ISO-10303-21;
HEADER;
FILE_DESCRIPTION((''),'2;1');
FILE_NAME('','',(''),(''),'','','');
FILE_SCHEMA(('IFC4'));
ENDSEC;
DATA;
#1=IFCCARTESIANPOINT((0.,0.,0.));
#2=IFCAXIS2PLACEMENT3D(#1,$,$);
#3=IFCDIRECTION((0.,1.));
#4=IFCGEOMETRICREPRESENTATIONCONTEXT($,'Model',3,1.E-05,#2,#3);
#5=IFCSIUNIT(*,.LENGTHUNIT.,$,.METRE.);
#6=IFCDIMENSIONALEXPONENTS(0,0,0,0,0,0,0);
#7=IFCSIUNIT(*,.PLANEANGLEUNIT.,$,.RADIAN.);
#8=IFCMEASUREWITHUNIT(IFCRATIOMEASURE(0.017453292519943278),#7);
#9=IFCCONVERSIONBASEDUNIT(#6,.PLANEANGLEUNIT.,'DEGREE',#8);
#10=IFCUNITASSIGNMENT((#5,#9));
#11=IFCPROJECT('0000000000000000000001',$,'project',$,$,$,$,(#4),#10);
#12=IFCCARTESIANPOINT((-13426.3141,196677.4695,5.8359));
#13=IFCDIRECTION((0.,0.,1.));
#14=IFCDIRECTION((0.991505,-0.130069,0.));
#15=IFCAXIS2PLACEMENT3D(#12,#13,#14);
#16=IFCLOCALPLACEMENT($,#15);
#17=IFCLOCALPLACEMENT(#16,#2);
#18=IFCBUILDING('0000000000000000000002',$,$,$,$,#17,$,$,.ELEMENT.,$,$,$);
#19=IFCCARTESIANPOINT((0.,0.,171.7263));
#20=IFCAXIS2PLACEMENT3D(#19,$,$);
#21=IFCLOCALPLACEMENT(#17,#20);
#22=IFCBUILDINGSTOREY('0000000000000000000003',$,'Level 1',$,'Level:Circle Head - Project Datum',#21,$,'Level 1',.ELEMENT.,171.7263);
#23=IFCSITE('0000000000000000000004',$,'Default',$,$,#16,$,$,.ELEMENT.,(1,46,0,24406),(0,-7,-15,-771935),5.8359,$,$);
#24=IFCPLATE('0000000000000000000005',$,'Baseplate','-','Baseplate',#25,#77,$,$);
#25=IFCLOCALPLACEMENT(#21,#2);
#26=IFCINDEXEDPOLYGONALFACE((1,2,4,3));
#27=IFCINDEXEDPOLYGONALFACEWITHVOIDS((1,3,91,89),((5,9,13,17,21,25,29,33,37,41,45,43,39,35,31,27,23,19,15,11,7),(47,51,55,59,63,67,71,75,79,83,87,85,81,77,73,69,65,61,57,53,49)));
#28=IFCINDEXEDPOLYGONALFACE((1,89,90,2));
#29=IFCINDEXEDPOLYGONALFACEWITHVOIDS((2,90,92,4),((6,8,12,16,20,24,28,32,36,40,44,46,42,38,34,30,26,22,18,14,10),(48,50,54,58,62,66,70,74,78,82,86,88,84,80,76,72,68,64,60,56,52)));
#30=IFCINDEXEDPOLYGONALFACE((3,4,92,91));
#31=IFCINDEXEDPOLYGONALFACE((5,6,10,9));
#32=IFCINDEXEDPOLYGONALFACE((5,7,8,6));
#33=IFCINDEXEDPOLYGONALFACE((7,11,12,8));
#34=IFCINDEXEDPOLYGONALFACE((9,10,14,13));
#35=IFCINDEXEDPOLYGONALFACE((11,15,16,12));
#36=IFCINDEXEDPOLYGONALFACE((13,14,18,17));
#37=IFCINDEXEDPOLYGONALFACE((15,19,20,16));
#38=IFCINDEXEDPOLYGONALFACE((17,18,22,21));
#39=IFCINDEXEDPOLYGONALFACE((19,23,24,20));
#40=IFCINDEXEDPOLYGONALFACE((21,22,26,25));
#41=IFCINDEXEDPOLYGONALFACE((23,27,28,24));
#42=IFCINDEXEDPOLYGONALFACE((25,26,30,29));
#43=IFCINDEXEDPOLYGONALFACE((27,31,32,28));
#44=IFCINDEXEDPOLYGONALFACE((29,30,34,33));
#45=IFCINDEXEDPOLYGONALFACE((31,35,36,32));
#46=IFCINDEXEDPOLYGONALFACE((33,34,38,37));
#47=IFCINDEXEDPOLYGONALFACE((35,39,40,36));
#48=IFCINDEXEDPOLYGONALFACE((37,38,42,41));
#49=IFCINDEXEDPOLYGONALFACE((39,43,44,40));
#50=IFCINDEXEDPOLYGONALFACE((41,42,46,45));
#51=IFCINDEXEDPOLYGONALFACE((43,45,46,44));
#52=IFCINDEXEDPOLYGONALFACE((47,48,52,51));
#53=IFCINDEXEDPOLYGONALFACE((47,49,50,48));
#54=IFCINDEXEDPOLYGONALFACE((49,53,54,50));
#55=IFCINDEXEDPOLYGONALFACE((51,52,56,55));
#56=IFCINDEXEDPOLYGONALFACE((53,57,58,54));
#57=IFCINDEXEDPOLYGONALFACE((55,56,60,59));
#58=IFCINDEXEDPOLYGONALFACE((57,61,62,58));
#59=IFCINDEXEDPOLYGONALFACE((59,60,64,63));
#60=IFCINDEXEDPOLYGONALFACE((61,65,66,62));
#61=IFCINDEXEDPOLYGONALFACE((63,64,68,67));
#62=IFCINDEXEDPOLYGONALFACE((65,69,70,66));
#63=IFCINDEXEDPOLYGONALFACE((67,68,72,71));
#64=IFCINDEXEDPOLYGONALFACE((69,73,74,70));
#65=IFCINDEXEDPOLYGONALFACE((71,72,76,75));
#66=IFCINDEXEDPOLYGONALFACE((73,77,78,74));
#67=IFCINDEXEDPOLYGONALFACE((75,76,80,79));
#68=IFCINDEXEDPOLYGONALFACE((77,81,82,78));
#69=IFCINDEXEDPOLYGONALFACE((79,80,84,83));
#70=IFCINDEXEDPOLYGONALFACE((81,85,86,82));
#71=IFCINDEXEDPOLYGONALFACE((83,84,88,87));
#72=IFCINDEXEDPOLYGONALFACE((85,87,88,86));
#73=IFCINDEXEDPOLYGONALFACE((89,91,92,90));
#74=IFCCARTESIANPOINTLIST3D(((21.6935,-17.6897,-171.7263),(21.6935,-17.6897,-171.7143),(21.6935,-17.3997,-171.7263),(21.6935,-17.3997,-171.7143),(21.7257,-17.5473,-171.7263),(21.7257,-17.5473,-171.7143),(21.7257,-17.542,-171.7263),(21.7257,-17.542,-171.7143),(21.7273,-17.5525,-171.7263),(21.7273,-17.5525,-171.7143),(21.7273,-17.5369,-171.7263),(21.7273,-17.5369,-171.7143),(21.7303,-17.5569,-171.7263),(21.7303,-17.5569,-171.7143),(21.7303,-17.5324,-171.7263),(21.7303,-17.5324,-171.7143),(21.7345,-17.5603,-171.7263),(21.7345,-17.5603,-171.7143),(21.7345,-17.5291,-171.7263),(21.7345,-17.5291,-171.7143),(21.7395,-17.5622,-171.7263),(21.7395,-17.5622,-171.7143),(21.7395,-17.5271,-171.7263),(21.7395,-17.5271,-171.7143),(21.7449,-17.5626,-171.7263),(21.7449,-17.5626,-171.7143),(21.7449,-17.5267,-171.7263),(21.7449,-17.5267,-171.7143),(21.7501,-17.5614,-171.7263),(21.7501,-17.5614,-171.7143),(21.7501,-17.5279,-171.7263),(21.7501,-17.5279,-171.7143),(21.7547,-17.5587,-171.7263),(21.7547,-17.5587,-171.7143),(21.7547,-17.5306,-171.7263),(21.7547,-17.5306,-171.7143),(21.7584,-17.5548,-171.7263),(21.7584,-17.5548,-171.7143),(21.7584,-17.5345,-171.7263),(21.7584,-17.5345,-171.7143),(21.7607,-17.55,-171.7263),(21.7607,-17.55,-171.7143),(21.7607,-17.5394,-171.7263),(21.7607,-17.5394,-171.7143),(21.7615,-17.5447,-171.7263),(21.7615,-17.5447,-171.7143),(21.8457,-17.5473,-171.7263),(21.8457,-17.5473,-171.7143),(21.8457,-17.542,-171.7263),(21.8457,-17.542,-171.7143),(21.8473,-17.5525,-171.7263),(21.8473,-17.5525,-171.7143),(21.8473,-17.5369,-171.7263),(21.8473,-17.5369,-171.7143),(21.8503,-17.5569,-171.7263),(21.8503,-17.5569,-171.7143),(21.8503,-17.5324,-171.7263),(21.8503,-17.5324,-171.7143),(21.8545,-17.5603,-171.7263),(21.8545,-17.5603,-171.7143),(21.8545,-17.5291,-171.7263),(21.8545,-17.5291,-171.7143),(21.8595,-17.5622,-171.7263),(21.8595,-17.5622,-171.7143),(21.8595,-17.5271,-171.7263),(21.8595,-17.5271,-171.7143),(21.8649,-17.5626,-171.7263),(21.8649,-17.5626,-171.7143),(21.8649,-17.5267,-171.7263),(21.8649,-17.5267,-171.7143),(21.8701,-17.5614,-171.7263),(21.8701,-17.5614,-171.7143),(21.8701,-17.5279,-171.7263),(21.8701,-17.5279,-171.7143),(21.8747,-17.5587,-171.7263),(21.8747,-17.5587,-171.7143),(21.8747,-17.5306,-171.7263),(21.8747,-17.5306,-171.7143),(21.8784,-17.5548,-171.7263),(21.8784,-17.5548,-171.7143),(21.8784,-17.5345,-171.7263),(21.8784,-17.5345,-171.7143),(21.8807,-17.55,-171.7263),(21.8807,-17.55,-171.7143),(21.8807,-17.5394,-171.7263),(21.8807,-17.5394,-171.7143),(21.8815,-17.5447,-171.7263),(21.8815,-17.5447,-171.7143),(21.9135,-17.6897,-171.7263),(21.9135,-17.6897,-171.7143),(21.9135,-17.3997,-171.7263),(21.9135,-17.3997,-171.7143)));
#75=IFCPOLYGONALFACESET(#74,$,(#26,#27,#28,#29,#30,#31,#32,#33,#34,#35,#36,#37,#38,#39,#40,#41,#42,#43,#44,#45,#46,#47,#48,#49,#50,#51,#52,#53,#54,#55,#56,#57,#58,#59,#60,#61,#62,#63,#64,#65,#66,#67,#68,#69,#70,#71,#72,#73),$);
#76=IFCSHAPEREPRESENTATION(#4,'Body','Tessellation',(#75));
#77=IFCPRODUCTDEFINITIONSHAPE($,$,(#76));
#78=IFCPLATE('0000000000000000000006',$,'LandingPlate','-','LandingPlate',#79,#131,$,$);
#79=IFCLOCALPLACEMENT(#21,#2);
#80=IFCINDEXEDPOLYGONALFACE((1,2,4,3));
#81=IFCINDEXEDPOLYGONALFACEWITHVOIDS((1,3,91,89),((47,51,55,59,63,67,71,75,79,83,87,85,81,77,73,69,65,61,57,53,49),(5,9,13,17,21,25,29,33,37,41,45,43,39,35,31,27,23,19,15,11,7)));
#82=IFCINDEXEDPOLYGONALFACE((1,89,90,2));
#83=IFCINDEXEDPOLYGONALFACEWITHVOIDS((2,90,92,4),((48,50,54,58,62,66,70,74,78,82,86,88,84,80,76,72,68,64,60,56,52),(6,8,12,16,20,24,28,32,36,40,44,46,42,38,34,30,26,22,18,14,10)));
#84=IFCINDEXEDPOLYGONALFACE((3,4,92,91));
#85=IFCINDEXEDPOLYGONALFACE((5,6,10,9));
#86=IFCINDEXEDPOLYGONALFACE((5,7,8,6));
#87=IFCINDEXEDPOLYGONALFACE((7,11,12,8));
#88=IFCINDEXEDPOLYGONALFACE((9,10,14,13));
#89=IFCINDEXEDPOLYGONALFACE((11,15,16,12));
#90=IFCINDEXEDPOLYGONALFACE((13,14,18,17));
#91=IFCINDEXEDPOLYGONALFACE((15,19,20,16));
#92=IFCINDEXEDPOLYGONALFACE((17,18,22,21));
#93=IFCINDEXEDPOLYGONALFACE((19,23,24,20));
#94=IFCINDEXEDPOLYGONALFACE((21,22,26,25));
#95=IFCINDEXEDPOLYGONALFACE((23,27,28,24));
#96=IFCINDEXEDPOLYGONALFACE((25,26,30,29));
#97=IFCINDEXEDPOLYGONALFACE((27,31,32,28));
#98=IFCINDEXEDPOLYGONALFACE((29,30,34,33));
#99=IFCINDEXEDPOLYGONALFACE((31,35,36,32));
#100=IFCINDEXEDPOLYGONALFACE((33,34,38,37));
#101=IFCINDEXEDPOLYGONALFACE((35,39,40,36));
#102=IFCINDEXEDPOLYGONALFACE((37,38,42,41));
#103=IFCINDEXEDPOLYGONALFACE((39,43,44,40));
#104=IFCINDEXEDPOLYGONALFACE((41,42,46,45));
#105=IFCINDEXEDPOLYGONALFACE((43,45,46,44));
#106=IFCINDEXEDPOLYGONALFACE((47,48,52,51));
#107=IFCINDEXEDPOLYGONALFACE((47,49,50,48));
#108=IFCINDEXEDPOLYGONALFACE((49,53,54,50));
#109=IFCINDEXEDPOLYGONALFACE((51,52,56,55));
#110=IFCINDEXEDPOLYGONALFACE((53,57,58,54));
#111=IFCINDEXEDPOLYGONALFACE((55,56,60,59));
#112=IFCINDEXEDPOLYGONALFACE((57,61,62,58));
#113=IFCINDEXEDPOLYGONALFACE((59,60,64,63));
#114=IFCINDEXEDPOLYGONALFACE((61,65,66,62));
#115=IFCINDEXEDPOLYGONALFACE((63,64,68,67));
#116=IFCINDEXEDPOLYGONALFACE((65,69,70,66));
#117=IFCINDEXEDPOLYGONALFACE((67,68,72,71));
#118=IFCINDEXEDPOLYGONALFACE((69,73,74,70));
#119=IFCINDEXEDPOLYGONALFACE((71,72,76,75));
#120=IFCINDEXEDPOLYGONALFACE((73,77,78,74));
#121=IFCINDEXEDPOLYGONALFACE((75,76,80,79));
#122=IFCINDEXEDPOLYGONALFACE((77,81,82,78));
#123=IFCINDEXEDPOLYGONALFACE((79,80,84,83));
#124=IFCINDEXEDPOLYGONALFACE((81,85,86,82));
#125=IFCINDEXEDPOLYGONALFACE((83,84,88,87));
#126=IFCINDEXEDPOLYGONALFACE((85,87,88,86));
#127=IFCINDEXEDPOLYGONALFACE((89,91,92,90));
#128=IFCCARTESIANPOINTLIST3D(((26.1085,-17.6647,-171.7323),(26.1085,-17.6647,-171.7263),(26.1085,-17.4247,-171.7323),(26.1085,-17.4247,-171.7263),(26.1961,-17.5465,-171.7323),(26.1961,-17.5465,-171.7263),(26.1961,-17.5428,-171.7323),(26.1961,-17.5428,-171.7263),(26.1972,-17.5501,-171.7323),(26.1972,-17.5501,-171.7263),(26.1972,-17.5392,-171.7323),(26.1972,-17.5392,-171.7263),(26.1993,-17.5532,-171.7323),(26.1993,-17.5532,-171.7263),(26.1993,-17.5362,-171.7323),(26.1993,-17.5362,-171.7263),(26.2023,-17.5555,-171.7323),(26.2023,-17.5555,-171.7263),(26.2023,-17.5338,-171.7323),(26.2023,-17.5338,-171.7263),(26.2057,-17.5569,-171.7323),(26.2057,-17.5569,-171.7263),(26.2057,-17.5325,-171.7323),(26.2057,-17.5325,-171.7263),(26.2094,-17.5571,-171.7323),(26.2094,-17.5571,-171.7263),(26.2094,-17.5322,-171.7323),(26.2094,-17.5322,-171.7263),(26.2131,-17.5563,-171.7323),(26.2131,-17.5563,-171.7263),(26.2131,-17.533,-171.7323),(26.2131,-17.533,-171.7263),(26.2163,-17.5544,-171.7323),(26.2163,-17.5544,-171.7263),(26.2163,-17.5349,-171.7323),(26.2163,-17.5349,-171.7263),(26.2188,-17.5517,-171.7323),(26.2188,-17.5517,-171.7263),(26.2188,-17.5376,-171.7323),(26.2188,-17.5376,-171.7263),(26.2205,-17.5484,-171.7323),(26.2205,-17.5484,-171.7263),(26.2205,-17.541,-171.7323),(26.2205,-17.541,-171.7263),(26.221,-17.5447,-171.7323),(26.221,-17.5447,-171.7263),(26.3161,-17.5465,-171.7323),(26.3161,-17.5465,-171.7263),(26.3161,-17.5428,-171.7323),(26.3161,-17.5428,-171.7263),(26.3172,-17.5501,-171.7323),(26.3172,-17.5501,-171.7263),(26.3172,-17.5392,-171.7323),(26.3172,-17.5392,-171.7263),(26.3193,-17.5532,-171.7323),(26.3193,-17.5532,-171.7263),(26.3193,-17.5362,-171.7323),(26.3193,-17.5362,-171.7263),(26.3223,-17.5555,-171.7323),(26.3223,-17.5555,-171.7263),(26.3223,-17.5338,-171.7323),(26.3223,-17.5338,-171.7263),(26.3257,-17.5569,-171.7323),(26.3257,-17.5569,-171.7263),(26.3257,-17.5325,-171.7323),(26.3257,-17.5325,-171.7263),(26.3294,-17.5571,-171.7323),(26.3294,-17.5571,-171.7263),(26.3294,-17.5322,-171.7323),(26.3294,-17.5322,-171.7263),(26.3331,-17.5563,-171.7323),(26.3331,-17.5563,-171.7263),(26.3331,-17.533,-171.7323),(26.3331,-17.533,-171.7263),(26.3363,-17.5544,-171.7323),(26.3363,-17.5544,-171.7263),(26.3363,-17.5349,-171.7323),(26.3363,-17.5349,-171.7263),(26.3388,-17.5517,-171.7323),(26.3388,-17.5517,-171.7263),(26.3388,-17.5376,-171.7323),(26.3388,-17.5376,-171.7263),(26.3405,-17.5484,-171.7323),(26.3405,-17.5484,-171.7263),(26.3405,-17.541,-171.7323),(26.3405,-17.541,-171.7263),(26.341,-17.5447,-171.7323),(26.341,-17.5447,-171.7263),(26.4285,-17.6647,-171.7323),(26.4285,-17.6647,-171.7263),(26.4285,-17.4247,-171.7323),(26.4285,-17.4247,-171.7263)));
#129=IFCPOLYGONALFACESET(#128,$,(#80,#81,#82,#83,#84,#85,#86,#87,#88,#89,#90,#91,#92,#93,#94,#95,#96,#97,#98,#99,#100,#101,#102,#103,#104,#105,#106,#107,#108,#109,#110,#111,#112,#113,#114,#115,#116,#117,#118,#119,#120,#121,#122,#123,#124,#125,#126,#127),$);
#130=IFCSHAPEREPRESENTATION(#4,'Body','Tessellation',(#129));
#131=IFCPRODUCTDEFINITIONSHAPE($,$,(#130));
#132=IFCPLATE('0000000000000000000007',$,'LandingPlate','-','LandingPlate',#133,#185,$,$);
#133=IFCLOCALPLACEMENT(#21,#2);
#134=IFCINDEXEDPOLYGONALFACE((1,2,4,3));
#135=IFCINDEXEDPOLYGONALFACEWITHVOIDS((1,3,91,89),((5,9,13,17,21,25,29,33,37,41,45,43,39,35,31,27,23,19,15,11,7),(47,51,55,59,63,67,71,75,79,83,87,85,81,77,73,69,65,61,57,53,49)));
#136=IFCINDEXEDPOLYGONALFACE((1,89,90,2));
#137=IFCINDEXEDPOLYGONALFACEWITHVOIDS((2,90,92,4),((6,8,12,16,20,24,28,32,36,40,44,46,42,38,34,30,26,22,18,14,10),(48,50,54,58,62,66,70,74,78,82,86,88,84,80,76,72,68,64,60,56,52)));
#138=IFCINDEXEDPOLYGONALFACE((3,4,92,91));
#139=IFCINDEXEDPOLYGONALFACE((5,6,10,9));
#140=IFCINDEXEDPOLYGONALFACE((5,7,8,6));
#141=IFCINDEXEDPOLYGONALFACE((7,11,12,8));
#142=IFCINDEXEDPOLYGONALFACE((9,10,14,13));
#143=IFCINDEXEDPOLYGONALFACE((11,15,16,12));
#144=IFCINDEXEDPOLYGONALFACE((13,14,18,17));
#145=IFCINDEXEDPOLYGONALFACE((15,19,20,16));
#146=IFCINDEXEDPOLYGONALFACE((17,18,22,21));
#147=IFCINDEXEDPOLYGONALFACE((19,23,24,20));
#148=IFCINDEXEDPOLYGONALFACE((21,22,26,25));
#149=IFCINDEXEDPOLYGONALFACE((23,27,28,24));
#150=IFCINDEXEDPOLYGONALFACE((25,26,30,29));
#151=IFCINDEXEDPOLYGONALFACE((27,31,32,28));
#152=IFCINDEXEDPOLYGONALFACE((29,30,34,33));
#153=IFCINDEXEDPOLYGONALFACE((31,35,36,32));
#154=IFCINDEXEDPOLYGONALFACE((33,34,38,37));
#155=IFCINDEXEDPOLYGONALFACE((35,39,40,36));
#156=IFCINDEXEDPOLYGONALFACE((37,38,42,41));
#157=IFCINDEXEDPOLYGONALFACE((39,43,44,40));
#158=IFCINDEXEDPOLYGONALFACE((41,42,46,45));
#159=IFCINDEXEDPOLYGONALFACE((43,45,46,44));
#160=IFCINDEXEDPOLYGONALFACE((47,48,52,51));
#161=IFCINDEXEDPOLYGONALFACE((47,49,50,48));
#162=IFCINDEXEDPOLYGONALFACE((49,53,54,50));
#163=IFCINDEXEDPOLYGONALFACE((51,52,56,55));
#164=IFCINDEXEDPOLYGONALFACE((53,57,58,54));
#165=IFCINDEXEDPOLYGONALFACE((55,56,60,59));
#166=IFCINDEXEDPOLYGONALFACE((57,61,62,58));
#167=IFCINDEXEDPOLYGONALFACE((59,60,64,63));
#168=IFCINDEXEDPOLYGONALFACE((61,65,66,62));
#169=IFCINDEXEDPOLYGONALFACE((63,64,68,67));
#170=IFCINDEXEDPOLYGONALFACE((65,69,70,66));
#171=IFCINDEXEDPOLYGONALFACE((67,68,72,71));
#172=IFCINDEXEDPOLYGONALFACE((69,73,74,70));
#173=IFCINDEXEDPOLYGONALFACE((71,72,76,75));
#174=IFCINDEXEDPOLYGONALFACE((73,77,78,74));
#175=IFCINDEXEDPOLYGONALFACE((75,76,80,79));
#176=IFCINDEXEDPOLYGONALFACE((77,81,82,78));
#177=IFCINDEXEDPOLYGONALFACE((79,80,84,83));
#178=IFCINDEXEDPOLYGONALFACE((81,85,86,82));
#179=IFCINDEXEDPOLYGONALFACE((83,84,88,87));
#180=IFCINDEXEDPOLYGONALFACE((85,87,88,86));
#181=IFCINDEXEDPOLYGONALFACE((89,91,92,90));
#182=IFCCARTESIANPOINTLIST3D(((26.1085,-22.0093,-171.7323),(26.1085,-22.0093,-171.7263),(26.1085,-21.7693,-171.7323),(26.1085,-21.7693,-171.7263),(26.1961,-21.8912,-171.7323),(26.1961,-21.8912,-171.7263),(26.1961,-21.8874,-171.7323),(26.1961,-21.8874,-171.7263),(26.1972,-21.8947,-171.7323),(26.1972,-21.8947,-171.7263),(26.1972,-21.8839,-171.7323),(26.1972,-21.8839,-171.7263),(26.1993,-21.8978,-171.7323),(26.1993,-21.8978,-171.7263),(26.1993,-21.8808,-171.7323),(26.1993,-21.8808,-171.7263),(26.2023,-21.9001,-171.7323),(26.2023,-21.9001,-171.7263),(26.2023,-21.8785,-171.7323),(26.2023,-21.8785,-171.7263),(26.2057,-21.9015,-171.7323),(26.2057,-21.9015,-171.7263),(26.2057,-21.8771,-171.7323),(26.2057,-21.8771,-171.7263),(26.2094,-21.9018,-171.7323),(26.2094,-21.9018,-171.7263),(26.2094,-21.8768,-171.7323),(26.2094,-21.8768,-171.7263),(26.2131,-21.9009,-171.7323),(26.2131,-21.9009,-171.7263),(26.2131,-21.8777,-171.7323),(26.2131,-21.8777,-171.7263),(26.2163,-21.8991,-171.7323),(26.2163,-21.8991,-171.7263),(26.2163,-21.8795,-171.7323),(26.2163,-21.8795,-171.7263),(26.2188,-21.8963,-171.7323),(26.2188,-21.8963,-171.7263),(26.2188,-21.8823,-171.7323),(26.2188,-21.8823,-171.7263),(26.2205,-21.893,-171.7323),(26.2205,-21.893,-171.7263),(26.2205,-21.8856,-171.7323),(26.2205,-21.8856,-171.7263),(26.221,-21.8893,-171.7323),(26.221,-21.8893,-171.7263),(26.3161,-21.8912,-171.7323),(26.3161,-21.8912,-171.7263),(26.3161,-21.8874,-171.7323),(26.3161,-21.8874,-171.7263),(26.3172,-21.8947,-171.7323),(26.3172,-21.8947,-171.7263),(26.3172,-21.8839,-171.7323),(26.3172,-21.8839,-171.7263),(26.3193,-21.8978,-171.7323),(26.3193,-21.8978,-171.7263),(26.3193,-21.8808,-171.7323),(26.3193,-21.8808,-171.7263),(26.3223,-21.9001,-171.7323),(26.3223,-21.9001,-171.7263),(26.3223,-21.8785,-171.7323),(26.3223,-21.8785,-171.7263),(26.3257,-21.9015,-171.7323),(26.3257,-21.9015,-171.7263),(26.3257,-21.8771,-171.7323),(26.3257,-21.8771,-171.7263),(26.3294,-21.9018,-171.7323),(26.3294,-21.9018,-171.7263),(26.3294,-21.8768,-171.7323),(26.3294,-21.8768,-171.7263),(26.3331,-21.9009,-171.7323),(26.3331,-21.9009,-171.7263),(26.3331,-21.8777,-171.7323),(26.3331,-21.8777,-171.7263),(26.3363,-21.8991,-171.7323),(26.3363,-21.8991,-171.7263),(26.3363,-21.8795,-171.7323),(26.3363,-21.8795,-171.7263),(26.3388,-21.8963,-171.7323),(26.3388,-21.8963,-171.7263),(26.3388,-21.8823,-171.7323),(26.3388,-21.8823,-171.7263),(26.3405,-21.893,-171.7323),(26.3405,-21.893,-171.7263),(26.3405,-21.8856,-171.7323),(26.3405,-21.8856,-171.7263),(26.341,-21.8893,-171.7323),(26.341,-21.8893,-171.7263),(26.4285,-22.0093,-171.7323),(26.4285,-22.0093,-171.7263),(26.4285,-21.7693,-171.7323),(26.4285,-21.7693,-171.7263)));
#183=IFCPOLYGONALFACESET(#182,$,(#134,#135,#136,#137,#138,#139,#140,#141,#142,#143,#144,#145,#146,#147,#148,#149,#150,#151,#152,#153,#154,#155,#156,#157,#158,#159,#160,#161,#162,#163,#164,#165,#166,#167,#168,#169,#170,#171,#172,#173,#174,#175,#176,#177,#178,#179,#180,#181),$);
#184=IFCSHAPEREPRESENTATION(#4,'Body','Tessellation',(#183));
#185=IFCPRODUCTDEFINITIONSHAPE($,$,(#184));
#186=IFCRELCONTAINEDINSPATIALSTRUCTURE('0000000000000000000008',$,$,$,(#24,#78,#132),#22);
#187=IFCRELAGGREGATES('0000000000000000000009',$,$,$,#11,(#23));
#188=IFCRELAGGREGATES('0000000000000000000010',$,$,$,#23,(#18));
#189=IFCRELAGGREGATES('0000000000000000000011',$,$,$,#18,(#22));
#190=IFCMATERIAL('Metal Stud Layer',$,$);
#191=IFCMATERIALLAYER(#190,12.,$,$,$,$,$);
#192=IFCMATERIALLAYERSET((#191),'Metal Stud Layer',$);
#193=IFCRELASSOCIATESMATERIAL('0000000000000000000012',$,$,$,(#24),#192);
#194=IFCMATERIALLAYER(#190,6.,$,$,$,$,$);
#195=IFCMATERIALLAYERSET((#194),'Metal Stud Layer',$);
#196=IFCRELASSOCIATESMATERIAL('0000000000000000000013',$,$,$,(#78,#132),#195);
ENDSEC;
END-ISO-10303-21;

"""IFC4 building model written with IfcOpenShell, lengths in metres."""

from ifc_helpers import new_model, entity, si_unit, converted_unit, direction, frame, frame_2d, origin, origin_with_axes, place, context, project, spatial, polyline, circle, outline, extrude, material, layer, layer_set, element, save


model = new_model("IFC4")

# Units and contexts
model_context = context("Model", 3, precision=1e-05, world=origin(), true_north=direction((0.0, 1.0)))
ifc_project = project(units=[si_unit("LENGTHUNIT", "METRE"), converted_unit("PLANEANGLEUNIT", "DEGREE", entity("IfcRatioMeasure", 0.017453292519943278), si_unit("PLANEANGLEUNIT", "RADIAN"), dimensions=[0, 0, 0, 0, 0, 0, 0])], contexts=[model_context])

# Site, building, storey
site_placement = place(None, frame((-13426.3141, 196677.4695, 5.8359), z_axis=(0.0, 0.0, 1.0), x_axis=(0.991505, -0.130069, 0.0)))
site = spatial("IfcSite", under=ifc_project, at=site_placement, Name="Default", CompositionType="ELEMENT", RefLatitude=(1, 46, 0, 24406), RefLongitude=(0, -7, -15, -771935), RefElevation=5.8359)
building_placement = place(site_placement, origin())
building = spatial("IfcBuilding", under=site, at=building_placement, CompositionType="ELEMENT")
storey_placement = place(building_placement, frame((0.0, 0.0, 171.7263)))
storey = spatial("IfcBuildingStorey", under=building, at=storey_placement, Name="Level 1", ObjectType="Level:Circle Head - Project Datum", LongName="Level 1", CompositionType="ELEMENT", Elevation=171.7263)

# Plates, openings
ifc_material = material(Name="Metal Stud Layer")
ifc_layer_1 = layer(ifc_material, 12.0)
ifc_layer_set_1 = layer_set([ifc_layer_1], Name="Metal Stud Layer")
plate_1_placement = place(storey_placement, frame((21.6935, -17.3997, -171.7143), z_axis=(0.0, 0.0, -1.0), x_axis=(1.0, 0.0, 0.0)))
plate_1 = element("IfcPlate", 1, at=plate_1_placement, inside=storey, material=ifc_layer_set_1, Name="Baseplate", Description="-", ObjectType="Baseplate", context=model_context, shape_type="SweptSolid", body=[
    extrude(outline(polyline([(0.0, 0.0), (0.22, 0.0), (0.22, 0.29), (0.0, 0.29), (0.0, 0.0)])), origin_with_axes(), (0.0, 0.0, 1.0), 0.012),
])
opening_1_placement = place(plate_1_placement, frame((0.11, 0.145, 0.0125), z_axis=(0.0, 0.0, -1.0), x_axis=(1.0, 0.0, 0.0)))
element("IfcOpeningElement", 2, at=opening_1_placement, cuts=plate_1, ObjectType="Opening", context=model_context, shape_type="SweptSolid", body=[
    extrude(circle(Radius=0.018, at=frame_2d((0.06, 0.0), x_axis=(1.0, 0.0))), origin(), (0.0, 0.0, 1.0), 0.013),
])
opening_2_placement = place(plate_1_placement, frame((0.11, 0.145, 0.0125), z_axis=(0.0, 0.0, -1.0), x_axis=(1.0, 0.0, 0.0)))
element("IfcOpeningElement", 3, at=opening_2_placement, cuts=plate_1, ObjectType="Opening", context=model_context, shape_type="SweptSolid", body=[
    extrude(circle(Radius=0.018, at=frame_2d((-0.06, 0.0), x_axis=(1.0, 0.0))), origin(), (0.0, 0.0, 1.0), 0.013),
])
ifc_layer_2 = layer(ifc_material, 6.0)
ifc_layer_set_2 = layer_set([ifc_layer_2], Name="Metal Stud Layer")
plate_2_placement = place(storey_placement, frame((26.2685, -17.5447, -171.7263), z_axis=(0.0, 0.0, -1.0), x_axis=(0.0, 1.0, 0.0)))
plate_2 = element("IfcPlate", 4, at=plate_2_placement, inside=storey, material=ifc_layer_set_2, Name="LandingPlate", Description="-", ObjectType="LandingPlate", context=model_context, shape_type="SweptSolid", body=[
    extrude(outline(polyline([(-0.12, -0.16), (0.12, -0.16), (0.12, 0.16), (-0.12, 0.16), (-0.12, -0.16)])), origin_with_axes(), (0.0, 0.0, 1.0), 0.006),
])
opening_3_placement = place(plate_2_placement, frame((0.0, 0.0, 0.0065), z_axis=(0.0, 0.0, -1.0), x_axis=(0.0, 1.0, 0.0)))
element("IfcOpeningElement", 5, at=opening_3_placement, cuts=plate_2, ObjectType="Opening", context=model_context, shape_type="SweptSolid", body=[
    extrude(circle(Radius=0.0125, at=frame_2d((0.06, 0.0), x_axis=(1.0, 0.0))), origin(), (0.0, 0.0, 1.0), 0.007),
])
opening_4_placement = place(plate_2_placement, frame((0.0, 0.0, 0.0065), z_axis=(0.0, 0.0, -1.0), x_axis=(0.0, 1.0, 0.0)))
element("IfcOpeningElement", 6, at=opening_4_placement, cuts=plate_2, ObjectType="Opening", context=model_context, shape_type="SweptSolid", body=[
    extrude(circle(Radius=0.0125, at=frame_2d((-0.06, 0.0), x_axis=(1.0, 0.0))), origin(), (0.0, 0.0, 1.0), 0.007),
])
plate_3_placement = place(storey_placement, frame((26.2685, -21.8893, -171.7263), z_axis=(0.0, 0.0, -1.0), x_axis=(0.0, 1.0, 0.0)))
plate_3 = element("IfcPlate", 7, at=plate_3_placement, inside=storey, material=ifc_layer_set_2, Name="LandingPlate", Description="-", ObjectType="LandingPlate", context=model_context, shape_type="SweptSolid", body=[
    extrude(outline(polyline([(-0.12, -0.16), (0.12, -0.16), (0.12, 0.16), (-0.12, 0.16), (-0.12, -0.16)])), origin_with_axes(), (0.0, 0.0, 1.0), 0.006),
])
opening_5_placement = place(plate_3_placement, frame((0.0, 0.0, 0.0065), z_axis=(0.0, 0.0, -1.0), x_axis=(0.0, 1.0, 0.0)))
element("IfcOpeningElement", 8, at=opening_5_placement, cuts=plate_3, ObjectType="Opening", context=model_context, shape_type="SweptSolid", body=[
    extrude(circle(Radius=0.0125, at=frame_2d((0.06, 0.0), x_axis=(1.0, 0.0))), origin(), (0.0, 0.0, 1.0), 0.007),
])
opening_6_placement = place(plate_3_placement, frame((0.0, 0.0, 0.0065), z_axis=(0.0, 0.0, -1.0), x_axis=(0.0, 1.0, 0.0)))
element("IfcOpeningElement", 9, at=opening_6_placement, cuts=plate_3, ObjectType="Opening", context=model_context, shape_type="SweptSolid", body=[
    extrude(circle(Radius=0.0125, at=frame_2d((-0.06, 0.0), x_axis=(1.0, 0.0))), origin(), (0.0, 0.0, 1.0), 0.007),
])

save(model, "model.ifc")
